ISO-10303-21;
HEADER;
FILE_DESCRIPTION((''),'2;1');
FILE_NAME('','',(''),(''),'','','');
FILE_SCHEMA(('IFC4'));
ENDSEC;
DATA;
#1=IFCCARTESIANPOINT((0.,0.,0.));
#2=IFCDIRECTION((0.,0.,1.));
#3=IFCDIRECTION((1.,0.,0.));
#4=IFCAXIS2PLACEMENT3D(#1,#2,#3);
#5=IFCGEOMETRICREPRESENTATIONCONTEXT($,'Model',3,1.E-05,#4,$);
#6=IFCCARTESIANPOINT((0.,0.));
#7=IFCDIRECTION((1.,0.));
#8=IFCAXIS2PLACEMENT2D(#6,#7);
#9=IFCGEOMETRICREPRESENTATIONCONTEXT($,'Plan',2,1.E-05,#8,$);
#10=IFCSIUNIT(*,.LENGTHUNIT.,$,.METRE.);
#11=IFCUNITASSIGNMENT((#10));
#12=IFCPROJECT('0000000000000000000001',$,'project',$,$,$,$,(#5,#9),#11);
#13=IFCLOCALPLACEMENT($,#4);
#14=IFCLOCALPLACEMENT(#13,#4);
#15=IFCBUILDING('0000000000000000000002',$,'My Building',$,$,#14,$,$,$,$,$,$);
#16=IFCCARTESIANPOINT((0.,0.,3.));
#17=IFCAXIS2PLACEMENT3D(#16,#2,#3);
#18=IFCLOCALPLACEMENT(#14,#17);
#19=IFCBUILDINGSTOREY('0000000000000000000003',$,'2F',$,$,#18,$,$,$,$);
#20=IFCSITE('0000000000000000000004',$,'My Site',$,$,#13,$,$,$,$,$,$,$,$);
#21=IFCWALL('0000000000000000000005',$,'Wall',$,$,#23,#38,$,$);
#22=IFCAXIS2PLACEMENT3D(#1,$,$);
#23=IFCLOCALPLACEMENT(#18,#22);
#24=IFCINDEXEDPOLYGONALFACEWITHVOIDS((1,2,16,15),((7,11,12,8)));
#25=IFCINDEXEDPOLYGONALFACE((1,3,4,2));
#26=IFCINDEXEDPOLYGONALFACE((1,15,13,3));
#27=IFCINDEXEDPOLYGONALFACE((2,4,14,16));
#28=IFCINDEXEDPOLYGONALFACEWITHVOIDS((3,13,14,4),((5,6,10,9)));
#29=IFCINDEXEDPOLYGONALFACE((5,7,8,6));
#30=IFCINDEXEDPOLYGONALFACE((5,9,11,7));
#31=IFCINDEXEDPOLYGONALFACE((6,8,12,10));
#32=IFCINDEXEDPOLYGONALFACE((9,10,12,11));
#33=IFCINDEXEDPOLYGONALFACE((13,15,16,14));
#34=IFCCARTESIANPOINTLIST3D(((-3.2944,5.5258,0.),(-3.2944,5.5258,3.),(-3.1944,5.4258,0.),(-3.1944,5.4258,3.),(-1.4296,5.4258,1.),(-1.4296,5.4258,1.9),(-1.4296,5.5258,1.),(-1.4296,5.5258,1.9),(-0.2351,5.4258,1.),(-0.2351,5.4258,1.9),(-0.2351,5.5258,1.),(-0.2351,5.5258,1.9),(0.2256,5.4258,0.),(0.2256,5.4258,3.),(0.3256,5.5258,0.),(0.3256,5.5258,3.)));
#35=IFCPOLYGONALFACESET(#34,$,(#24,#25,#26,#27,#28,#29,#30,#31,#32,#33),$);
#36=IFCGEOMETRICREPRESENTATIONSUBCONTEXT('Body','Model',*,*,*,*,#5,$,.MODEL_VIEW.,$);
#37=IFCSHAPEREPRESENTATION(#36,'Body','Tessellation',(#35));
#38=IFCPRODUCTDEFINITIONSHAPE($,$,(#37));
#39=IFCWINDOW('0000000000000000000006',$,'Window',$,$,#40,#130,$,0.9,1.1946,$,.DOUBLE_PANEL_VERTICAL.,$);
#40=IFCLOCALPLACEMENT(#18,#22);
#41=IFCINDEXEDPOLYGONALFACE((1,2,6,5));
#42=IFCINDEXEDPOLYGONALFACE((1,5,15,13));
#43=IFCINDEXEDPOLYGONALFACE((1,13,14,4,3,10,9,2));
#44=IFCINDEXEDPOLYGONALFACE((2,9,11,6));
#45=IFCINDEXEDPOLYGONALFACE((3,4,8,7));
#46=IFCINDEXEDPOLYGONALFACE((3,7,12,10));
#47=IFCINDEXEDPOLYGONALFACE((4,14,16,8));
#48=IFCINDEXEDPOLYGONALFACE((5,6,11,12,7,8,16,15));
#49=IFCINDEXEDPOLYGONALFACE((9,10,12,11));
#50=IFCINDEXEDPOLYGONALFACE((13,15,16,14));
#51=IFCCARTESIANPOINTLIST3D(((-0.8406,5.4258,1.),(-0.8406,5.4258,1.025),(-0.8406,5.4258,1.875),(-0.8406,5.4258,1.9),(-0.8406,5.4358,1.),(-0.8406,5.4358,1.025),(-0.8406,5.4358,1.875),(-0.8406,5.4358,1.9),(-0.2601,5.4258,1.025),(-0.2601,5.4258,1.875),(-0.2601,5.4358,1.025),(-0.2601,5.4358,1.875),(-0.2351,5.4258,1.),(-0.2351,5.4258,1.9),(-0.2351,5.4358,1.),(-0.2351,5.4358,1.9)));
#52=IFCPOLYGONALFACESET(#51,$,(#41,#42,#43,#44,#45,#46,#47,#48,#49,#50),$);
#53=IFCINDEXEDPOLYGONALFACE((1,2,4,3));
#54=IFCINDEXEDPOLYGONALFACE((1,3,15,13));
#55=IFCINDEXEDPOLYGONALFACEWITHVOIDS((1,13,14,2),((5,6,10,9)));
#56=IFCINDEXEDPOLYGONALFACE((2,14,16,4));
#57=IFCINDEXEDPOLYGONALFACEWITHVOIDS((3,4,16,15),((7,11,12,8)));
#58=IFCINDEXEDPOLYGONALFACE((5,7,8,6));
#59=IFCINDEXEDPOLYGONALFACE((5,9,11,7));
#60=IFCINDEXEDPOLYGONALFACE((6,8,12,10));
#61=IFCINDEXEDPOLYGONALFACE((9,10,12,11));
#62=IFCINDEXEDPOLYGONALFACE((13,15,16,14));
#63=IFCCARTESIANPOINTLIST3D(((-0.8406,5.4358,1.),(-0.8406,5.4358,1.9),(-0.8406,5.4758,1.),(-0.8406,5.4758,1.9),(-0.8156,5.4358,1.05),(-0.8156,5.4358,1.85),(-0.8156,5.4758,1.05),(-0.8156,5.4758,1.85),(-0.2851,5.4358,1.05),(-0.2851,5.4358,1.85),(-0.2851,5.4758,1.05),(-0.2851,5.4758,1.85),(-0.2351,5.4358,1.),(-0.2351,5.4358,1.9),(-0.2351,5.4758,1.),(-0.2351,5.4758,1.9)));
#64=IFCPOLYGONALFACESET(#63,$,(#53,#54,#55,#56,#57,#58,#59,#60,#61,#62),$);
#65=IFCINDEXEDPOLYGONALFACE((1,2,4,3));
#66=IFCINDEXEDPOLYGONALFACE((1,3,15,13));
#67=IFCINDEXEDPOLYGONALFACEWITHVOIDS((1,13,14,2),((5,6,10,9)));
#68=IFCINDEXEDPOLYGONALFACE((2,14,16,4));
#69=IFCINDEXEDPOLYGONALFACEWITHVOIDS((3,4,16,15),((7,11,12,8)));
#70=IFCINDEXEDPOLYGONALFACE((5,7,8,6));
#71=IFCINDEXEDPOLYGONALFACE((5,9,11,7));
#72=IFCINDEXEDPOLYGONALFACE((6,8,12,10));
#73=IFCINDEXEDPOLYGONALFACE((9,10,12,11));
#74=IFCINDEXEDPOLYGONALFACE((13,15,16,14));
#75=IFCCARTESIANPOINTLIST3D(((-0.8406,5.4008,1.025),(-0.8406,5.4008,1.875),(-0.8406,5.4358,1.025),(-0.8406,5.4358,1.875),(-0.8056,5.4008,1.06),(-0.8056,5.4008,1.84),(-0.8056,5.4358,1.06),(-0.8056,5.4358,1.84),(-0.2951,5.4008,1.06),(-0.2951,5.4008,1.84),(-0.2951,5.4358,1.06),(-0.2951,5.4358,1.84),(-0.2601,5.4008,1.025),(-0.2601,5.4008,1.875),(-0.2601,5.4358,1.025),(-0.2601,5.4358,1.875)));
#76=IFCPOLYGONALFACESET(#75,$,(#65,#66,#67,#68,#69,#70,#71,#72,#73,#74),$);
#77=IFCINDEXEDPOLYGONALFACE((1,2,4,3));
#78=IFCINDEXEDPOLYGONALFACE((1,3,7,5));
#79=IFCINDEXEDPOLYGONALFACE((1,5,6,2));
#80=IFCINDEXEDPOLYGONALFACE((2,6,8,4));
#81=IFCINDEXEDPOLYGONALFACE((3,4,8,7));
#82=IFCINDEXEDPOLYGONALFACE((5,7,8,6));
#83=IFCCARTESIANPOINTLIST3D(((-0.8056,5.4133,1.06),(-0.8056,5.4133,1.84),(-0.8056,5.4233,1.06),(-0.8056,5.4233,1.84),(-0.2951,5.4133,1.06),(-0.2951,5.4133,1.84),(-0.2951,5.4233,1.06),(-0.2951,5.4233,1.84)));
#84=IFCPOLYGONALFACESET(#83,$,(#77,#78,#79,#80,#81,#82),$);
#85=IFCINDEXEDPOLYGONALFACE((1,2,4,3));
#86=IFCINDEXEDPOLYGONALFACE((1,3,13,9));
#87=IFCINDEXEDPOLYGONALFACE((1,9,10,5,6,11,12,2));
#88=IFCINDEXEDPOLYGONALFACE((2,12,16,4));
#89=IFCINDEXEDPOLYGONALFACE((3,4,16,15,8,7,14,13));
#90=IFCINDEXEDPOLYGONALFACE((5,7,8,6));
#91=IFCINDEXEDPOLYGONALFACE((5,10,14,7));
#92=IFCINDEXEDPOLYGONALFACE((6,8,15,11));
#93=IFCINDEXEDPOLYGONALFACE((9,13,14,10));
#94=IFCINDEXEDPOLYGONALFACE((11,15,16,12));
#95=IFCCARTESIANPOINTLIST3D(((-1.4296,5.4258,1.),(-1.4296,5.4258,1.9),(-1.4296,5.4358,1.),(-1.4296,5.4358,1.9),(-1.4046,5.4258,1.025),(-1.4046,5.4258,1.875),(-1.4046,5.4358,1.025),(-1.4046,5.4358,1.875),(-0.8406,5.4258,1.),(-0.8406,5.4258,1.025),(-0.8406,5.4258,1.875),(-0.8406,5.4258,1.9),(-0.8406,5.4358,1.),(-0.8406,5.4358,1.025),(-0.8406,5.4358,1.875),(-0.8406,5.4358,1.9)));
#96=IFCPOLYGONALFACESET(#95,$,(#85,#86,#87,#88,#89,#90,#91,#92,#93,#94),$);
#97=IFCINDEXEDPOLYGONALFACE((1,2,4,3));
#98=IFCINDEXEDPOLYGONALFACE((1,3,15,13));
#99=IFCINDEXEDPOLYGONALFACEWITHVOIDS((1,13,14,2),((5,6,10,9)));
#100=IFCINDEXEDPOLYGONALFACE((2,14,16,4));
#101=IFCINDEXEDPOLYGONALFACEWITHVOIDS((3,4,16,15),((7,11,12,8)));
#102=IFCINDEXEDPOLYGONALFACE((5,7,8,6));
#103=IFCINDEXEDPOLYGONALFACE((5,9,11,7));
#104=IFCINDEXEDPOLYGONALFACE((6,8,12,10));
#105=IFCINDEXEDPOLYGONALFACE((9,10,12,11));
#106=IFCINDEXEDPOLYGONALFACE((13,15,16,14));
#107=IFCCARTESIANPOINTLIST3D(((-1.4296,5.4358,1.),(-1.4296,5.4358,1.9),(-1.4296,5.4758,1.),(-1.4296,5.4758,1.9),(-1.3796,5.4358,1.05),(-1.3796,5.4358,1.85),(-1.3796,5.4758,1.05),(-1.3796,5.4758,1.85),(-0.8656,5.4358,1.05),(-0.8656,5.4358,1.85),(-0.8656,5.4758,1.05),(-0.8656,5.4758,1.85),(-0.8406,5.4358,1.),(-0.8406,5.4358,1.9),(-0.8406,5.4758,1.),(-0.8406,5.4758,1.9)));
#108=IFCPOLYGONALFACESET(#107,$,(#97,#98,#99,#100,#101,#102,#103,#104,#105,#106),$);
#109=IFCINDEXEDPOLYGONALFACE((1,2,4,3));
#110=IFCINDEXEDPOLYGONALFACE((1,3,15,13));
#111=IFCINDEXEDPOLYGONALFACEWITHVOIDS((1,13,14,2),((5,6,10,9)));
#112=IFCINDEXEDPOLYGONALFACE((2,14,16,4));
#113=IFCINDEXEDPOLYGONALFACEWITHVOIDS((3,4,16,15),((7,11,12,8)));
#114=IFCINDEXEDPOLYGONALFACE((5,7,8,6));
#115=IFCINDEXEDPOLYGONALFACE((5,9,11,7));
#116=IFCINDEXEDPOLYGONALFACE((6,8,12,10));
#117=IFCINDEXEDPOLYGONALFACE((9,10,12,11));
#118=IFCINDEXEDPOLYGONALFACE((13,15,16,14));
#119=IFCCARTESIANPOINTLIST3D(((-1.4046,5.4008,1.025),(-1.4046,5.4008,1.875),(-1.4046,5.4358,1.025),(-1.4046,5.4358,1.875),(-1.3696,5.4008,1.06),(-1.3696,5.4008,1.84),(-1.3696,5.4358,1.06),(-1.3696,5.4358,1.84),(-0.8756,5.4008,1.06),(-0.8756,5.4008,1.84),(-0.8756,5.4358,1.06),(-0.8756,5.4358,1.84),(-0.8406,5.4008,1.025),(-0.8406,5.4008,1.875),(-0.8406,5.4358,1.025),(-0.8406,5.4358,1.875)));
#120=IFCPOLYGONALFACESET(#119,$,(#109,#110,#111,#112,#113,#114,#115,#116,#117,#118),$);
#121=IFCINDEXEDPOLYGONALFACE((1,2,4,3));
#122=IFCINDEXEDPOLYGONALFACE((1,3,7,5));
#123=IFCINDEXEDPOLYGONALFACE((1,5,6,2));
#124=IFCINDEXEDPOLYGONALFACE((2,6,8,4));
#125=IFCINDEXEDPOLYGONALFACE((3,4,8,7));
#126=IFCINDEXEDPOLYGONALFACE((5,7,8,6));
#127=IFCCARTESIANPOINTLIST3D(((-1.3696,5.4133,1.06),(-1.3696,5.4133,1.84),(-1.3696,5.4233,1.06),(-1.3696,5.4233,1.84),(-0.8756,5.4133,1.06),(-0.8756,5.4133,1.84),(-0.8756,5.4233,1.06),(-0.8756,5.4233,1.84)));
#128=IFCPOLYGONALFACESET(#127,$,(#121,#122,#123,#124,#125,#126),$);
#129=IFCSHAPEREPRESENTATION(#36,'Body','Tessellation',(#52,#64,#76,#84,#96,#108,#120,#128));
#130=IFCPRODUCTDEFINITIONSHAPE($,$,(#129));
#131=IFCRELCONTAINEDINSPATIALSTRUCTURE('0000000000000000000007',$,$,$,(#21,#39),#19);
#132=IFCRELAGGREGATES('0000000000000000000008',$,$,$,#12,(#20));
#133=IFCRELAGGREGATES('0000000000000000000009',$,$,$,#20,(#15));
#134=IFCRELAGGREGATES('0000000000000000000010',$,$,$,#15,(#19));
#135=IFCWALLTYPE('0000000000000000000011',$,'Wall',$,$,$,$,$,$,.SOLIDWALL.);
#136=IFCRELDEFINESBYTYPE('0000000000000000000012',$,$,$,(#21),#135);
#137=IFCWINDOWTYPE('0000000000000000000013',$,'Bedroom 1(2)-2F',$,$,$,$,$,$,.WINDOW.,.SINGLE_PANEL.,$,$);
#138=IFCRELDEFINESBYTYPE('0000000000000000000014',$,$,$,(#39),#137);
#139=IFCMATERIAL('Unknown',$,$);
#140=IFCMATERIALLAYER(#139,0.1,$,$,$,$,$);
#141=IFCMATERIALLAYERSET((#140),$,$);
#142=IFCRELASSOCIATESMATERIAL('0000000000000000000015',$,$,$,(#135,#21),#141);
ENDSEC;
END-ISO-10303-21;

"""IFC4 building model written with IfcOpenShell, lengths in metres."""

from ifc_helpers import new_model, entity, si_unit, frame, origin_with_axes, origin_2d_with_axis, place, context, subcontext, project, spatial, line, indexed_curve, outline, extrude, shape, source, transform, mapped, material, layer, layer_set, layer_usage, type_object, type_shapes, element, fill, save


model = new_model("IFC4")

# Units and contexts
model_context = context("Model", 3, precision=1e-05, world=origin_with_axes())
plan_context = context("Plan", 2, precision=1e-05, world=origin_2d_with_axis())
body_context_1 = subcontext(model_context, "Body", "Model", "MODEL_VIEW")
body_context_2 = subcontext(plan_context, "Body", "Plan", "PLAN_VIEW")
ifc_project = project(units=[si_unit("LENGTHUNIT", "METRE")], contexts=[model_context, plan_context])

# Site, building, storey
site_placement = place(None, origin_with_axes())
site = spatial("IfcSite", under=ifc_project, at=site_placement, Name="My Site")
building_placement = place(site_placement, origin_with_axes())
building = spatial("IfcBuilding", under=site, at=building_placement, Name="My Building")
storey_placement = place(building_placement, frame((0.0, 0.0, 3.0), z_axis=(0.0, 0.0, 1.0), x_axis=(1.0, 0.0, 0.0)))
storey = spatial("IfcBuildingStorey", under=building, at=storey_placement, Name="2F")

# Shared definitions
ifc_material = material(Name="Unknown")
ifc_layer = layer(ifc_material, 0.1)
ifc_layer_set = layer_set([ifc_layer])
wall_type = type_object("IfcWallType", Name="Wall", PredefinedType="SOLIDWALL", material=ifc_layer_set)

# Wall, opening, window
ifc_layer_usage_1 = layer_usage(ifc_layer_set, "AXIS2", "POSITIVE", 0.0)
wall_1_placement = place(storey_placement, frame((0.2256, 5.5258, 0.0), z_axis=(0.0, 0.0, 1.0), x_axis=(-1.0, 0.0, 0.0)))
wall_1 = element("IfcWall", 1, at=wall_1_placement, inside=storey, type_object=wall_type, material=ifc_layer_usage_1, Name="Wall", context=body_context_1, shape_type="SweptSolid", body=[
    extrude(outline(indexed_curve([(-0.1, 0.0), (0.0, 0.1), (3.42, 0.1), (3.52, 0.0)], segments=[line(1, 2, 3, 4, 1)])), origin_with_axes(), (0.0, 0.0, 1.0), 3.0),
])
shared_shape_1 = source(origin_with_axes(), body_context_1, "Body", "SweptSolid", [
    extrude(outline(indexed_curve([(0.0, 0.0), (1.1946, 0.0), (1.1946, 0.9), (0.0, 0.9)], segments=[line(1, 2, 3, 4, 1)])), frame((0.0, -0.6, 0.0), z_axis=(0.0, -1.0, 0.0), x_axis=(1.0, 0.0, 0.0)), (0.0, 0.0, -1.0), 1.2),
])
opening_1_placement = place(wall_1_placement, frame((0.4607, 0.0, 1.0), z_axis=(0.0, 0.0, 1.0), x_axis=(1.0, 0.0, 0.0)))
opening_1 = element("IfcOpeningElement", 2, at=opening_1_placement, cuts=wall_1, PredefinedType="OPENING", context=body_context_1, shape_type="MappedRepresentation", body=[
    mapped(shared_shape_1, transform((0.0, 0.0, 0.0), x_axis=(1.0, 0.0, 0.0), y_axis=(0.0, 1.0, 0.0), z_axis=(0.0, 0.0, 1.0), scale=1.0)),
])
window_type_1 = type_object("IfcWindowType", Name="Bedroom 1(2)-2F", PartitioningType="SINGLE_PANEL", PredefinedType="WINDOW")
shared_shape_2 = source(origin_with_axes(), body_context_1, "Body", "SweptSolid", [
    extrude(outline(indexed_curve([(0.6056, 0.0), (0.0, 0.0), (0.0, 0.9), (0.6056, 0.9), (0.6056, 0.875), (0.025, 0.875), (0.025, 0.025), (0.6056, 0.025)], segments=[line(1, 2, 3, 4, 5, 6, 7, 8, 1)])), frame((0.0, 0.09, 0.0), z_axis=(0.0, -1.0, 0.0), x_axis=(1.0, 0.0, 0.0)), (0.0, 0.0, -1.0), 0.01),
    extrude(outline(indexed_curve([(0.0, 0.0), (0.6056, 0.0), (0.6056, 0.9), (0.0, 0.9)], segments=[line(1, 2, 3, 4, 1)]), holes=[indexed_curve([(0.05, 0.05), (0.5806, 0.05), (0.5806, 0.85), (0.05, 0.85)], segments=[line(1, 2, 3, 4, 1)])]), frame((0.0, 0.05, 0.0), z_axis=(0.0, -1.0, 0.0), x_axis=(1.0, 0.0, 0.0)), (0.0, 0.0, -1.0), 0.04),
    extrude(outline(indexed_curve([(0.0, 0.0), (0.5806, 0.0), (0.5806, 0.85), (0.0, 0.85)], segments=[line(1, 2, 3, 4, 1)]), holes=[indexed_curve([(0.035, 0.035), (0.5456, 0.035), (0.5456, 0.815), (0.035, 0.815)], segments=[line(1, 2, 3, 4, 1)])]), frame((0.025, 0.09, 0.025), z_axis=(0.0, -1.0, 0.0), x_axis=(1.0, 0.0, 0.0)), (0.0, 0.0, -1.0), 0.035),
    extrude(outline(indexed_curve([(0.035, 0.035), (0.5456, 0.035), (0.5456, 0.815), (0.035, 0.815)], segments=[line(1, 2, 3, 4, 1)])), frame((0.025, 0.1025, 0.025), z_axis=(0.0, -1.0, 0.0), x_axis=(1.0, 0.0, 0.0)), (0.0, 0.0, -1.0), 0.01),
    extrude(outline(indexed_curve([(0.0, 0.9), (0.589, 0.9), (0.589, 0.0), (0.0, 0.0), (0.0, 0.025), (0.564, 0.025), (0.564, 0.875), (0.0, 0.875)], segments=[line(1, 2, 3, 4, 5, 6, 7, 8, 1)])), frame((0.6056, 0.09, 0.0), z_axis=(0.0, -1.0, 0.0), x_axis=(1.0, 0.0, 0.0)), (0.0, 0.0, -1.0), 0.01),
    extrude(outline(indexed_curve([(0.0, 0.0), (0.589, 0.0), (0.589, 0.9), (0.0, 0.9)], segments=[line(1, 2, 3, 4, 1)]), holes=[indexed_curve([(0.025, 0.05), (0.539, 0.05), (0.539, 0.85), (0.025, 0.85)], segments=[line(1, 2, 3, 4, 1)])]), frame((0.6056, 0.05, 0.0), z_axis=(0.0, -1.0, 0.0), x_axis=(1.0, 0.0, 0.0)), (0.0, 0.0, -1.0), 0.04),
    extrude(outline(indexed_curve([(0.0, 0.0), (0.564, 0.0), (0.564, 0.85), (0.0, 0.85)], segments=[line(1, 2, 3, 4, 1)]), holes=[indexed_curve([(0.035, 0.035), (0.529, 0.035), (0.529, 0.815), (0.035, 0.815)], segments=[line(1, 2, 3, 4, 1)])]), frame((0.6056, 0.09, 0.025), z_axis=(0.0, -1.0, 0.0), x_axis=(1.0, 0.0, 0.0)), (0.0, 0.0, -1.0), 0.035),
    extrude(outline(indexed_curve([(0.035, 0.035), (0.529, 0.035), (0.529, 0.815), (0.035, 0.815)], segments=[line(1, 2, 3, 4, 1)])), frame((0.6056, 0.1025, 0.025), z_axis=(0.0, -1.0, 0.0), x_axis=(1.0, 0.0, 0.0)), (0.0, 0.0, -1.0), 0.01),
])
shared_shape_3 = source(origin_with_axes(), body_context_2, "Body", "Curve2D", [
    entity("IfcIndexedPolyCurve", entity("IfcCartesianPointList2D", [[0.05, 0.05], [0.5806, 0.05]])),
    entity("IfcIndexedPolyCurve", entity("IfcCartesianPointList2D", [[0.0, 0.1], [0.025, 0.1], [0.025, 0.09], [0.05, 0.09], [0.05, 0.05], [0.0, 0.05]]), [entity("IfcLineIndex", [1, 2, 3, 4, 5, 6, 1])]),
    entity("IfcIndexedPolyCurve", entity("IfcCartesianPointList2D", [[0.6056, 0.1], [0.6056, 0.1], [0.6056, 0.09], [0.5806, 0.09], [0.5806, 0.05], [0.6056, 0.05]])),
    entity("IfcIndexedPolyCurve", entity("IfcCartesianPointList2D", [[0.025, 0.09], [0.06, 0.09], [0.06, 0.125], [0.025, 0.125]]), [entity("IfcLineIndex", [1, 2, 3, 4, 1])]),
    entity("IfcIndexedPolyCurve", entity("IfcCartesianPointList2D", [[0.6056, 0.09], [0.5706, 0.09], [0.5706, 0.125], [0.6056, 0.125]]), [entity("IfcLineIndex", [1, 2, 3, 4, 1])]),
    entity("IfcIndexedPolyCurve", entity("IfcCartesianPointList2D", [[0.06, 0.09], [0.5706, 0.09]])),
    entity("IfcIndexedPolyCurve", entity("IfcCartesianPointList2D", [[0.06, 0.125], [0.5706, 0.125]])),
    entity("IfcIndexedPolyCurve", entity("IfcCartesianPointList2D", [[0.06, 0.1075], [0.5706, 0.1075]])),
    entity("IfcIndexedPolyCurve", entity("IfcCartesianPointList2D", [[0.6306, 0.05], [1.1446, 0.05]])),
    entity("IfcIndexedPolyCurve", entity("IfcCartesianPointList2D", [[0.6056, 0.1], [0.6056, 0.1], [0.6056, 0.09], [0.6306, 0.09], [0.6306, 0.05], [0.6056, 0.05]])),
    entity("IfcIndexedPolyCurve", entity("IfcCartesianPointList2D", [[1.1946, 0.1], [1.1696, 0.1], [1.1696, 0.09], [1.1446, 0.09], [1.1446, 0.05], [1.1946, 0.05]]), [entity("IfcLineIndex", [1, 2, 3, 4, 5, 6, 1])]),
    entity("IfcIndexedPolyCurve", entity("IfcCartesianPointList2D", [[0.6056, 0.09], [0.6406, 0.09], [0.6406, 0.125], [0.6056, 0.125]]), [entity("IfcLineIndex", [1, 2, 3, 4, 1])]),
    entity("IfcIndexedPolyCurve", entity("IfcCartesianPointList2D", [[1.1696, 0.09], [1.1346, 0.09], [1.1346, 0.125], [1.1696, 0.125]]), [entity("IfcLineIndex", [1, 2, 3, 4, 1])]),
    entity("IfcIndexedPolyCurve", entity("IfcCartesianPointList2D", [[0.6406, 0.09], [1.1346, 0.09]])),
    entity("IfcIndexedPolyCurve", entity("IfcCartesianPointList2D", [[0.6406, 0.125], [1.1346, 0.125]])),
    entity("IfcIndexedPolyCurve", entity("IfcCartesianPointList2D", [[0.6406, 0.1075], [1.1346, 0.1075]])),
])
type_shapes(window_type_1, [shared_shape_2, shared_shape_3])
window_1_placement = place(opening_1_placement, frame((0.0, 0.0, 0.0), z_axis=(0.0, 0.0, 1.0), x_axis=(1.0, 0.0, 0.0)))
window_1 = element("IfcWindow", 3, at=window_1_placement, inside=storey, type_object=window_type_1, Name="Window", OverallHeight=0.9, OverallWidth=1.1946, PartitioningType="DOUBLE_PANEL_VERTICAL", shapes=[
    shape(body_context_1, "Body", "MappedRepresentation", [mapped(shared_shape_2, transform((0.0, 0.0, 0.0), x_axis=(1.0, 0.0, 0.0), y_axis=(0.0, 1.0, 0.0), z_axis=(0.0, 0.0, 1.0), scale=1.0))]),
    shape(body_context_2, "Body", "MappedRepresentation", [mapped(shared_shape_3, transform((0.0, 0.0, 0.0), x_axis=(1.0, 0.0, 0.0), y_axis=(0.0, 1.0, 0.0), z_axis=(0.0, 0.0, 1.0), scale=1.0))]),
])
fill(opening_1, window_1)

save(model, "model.ifc")
